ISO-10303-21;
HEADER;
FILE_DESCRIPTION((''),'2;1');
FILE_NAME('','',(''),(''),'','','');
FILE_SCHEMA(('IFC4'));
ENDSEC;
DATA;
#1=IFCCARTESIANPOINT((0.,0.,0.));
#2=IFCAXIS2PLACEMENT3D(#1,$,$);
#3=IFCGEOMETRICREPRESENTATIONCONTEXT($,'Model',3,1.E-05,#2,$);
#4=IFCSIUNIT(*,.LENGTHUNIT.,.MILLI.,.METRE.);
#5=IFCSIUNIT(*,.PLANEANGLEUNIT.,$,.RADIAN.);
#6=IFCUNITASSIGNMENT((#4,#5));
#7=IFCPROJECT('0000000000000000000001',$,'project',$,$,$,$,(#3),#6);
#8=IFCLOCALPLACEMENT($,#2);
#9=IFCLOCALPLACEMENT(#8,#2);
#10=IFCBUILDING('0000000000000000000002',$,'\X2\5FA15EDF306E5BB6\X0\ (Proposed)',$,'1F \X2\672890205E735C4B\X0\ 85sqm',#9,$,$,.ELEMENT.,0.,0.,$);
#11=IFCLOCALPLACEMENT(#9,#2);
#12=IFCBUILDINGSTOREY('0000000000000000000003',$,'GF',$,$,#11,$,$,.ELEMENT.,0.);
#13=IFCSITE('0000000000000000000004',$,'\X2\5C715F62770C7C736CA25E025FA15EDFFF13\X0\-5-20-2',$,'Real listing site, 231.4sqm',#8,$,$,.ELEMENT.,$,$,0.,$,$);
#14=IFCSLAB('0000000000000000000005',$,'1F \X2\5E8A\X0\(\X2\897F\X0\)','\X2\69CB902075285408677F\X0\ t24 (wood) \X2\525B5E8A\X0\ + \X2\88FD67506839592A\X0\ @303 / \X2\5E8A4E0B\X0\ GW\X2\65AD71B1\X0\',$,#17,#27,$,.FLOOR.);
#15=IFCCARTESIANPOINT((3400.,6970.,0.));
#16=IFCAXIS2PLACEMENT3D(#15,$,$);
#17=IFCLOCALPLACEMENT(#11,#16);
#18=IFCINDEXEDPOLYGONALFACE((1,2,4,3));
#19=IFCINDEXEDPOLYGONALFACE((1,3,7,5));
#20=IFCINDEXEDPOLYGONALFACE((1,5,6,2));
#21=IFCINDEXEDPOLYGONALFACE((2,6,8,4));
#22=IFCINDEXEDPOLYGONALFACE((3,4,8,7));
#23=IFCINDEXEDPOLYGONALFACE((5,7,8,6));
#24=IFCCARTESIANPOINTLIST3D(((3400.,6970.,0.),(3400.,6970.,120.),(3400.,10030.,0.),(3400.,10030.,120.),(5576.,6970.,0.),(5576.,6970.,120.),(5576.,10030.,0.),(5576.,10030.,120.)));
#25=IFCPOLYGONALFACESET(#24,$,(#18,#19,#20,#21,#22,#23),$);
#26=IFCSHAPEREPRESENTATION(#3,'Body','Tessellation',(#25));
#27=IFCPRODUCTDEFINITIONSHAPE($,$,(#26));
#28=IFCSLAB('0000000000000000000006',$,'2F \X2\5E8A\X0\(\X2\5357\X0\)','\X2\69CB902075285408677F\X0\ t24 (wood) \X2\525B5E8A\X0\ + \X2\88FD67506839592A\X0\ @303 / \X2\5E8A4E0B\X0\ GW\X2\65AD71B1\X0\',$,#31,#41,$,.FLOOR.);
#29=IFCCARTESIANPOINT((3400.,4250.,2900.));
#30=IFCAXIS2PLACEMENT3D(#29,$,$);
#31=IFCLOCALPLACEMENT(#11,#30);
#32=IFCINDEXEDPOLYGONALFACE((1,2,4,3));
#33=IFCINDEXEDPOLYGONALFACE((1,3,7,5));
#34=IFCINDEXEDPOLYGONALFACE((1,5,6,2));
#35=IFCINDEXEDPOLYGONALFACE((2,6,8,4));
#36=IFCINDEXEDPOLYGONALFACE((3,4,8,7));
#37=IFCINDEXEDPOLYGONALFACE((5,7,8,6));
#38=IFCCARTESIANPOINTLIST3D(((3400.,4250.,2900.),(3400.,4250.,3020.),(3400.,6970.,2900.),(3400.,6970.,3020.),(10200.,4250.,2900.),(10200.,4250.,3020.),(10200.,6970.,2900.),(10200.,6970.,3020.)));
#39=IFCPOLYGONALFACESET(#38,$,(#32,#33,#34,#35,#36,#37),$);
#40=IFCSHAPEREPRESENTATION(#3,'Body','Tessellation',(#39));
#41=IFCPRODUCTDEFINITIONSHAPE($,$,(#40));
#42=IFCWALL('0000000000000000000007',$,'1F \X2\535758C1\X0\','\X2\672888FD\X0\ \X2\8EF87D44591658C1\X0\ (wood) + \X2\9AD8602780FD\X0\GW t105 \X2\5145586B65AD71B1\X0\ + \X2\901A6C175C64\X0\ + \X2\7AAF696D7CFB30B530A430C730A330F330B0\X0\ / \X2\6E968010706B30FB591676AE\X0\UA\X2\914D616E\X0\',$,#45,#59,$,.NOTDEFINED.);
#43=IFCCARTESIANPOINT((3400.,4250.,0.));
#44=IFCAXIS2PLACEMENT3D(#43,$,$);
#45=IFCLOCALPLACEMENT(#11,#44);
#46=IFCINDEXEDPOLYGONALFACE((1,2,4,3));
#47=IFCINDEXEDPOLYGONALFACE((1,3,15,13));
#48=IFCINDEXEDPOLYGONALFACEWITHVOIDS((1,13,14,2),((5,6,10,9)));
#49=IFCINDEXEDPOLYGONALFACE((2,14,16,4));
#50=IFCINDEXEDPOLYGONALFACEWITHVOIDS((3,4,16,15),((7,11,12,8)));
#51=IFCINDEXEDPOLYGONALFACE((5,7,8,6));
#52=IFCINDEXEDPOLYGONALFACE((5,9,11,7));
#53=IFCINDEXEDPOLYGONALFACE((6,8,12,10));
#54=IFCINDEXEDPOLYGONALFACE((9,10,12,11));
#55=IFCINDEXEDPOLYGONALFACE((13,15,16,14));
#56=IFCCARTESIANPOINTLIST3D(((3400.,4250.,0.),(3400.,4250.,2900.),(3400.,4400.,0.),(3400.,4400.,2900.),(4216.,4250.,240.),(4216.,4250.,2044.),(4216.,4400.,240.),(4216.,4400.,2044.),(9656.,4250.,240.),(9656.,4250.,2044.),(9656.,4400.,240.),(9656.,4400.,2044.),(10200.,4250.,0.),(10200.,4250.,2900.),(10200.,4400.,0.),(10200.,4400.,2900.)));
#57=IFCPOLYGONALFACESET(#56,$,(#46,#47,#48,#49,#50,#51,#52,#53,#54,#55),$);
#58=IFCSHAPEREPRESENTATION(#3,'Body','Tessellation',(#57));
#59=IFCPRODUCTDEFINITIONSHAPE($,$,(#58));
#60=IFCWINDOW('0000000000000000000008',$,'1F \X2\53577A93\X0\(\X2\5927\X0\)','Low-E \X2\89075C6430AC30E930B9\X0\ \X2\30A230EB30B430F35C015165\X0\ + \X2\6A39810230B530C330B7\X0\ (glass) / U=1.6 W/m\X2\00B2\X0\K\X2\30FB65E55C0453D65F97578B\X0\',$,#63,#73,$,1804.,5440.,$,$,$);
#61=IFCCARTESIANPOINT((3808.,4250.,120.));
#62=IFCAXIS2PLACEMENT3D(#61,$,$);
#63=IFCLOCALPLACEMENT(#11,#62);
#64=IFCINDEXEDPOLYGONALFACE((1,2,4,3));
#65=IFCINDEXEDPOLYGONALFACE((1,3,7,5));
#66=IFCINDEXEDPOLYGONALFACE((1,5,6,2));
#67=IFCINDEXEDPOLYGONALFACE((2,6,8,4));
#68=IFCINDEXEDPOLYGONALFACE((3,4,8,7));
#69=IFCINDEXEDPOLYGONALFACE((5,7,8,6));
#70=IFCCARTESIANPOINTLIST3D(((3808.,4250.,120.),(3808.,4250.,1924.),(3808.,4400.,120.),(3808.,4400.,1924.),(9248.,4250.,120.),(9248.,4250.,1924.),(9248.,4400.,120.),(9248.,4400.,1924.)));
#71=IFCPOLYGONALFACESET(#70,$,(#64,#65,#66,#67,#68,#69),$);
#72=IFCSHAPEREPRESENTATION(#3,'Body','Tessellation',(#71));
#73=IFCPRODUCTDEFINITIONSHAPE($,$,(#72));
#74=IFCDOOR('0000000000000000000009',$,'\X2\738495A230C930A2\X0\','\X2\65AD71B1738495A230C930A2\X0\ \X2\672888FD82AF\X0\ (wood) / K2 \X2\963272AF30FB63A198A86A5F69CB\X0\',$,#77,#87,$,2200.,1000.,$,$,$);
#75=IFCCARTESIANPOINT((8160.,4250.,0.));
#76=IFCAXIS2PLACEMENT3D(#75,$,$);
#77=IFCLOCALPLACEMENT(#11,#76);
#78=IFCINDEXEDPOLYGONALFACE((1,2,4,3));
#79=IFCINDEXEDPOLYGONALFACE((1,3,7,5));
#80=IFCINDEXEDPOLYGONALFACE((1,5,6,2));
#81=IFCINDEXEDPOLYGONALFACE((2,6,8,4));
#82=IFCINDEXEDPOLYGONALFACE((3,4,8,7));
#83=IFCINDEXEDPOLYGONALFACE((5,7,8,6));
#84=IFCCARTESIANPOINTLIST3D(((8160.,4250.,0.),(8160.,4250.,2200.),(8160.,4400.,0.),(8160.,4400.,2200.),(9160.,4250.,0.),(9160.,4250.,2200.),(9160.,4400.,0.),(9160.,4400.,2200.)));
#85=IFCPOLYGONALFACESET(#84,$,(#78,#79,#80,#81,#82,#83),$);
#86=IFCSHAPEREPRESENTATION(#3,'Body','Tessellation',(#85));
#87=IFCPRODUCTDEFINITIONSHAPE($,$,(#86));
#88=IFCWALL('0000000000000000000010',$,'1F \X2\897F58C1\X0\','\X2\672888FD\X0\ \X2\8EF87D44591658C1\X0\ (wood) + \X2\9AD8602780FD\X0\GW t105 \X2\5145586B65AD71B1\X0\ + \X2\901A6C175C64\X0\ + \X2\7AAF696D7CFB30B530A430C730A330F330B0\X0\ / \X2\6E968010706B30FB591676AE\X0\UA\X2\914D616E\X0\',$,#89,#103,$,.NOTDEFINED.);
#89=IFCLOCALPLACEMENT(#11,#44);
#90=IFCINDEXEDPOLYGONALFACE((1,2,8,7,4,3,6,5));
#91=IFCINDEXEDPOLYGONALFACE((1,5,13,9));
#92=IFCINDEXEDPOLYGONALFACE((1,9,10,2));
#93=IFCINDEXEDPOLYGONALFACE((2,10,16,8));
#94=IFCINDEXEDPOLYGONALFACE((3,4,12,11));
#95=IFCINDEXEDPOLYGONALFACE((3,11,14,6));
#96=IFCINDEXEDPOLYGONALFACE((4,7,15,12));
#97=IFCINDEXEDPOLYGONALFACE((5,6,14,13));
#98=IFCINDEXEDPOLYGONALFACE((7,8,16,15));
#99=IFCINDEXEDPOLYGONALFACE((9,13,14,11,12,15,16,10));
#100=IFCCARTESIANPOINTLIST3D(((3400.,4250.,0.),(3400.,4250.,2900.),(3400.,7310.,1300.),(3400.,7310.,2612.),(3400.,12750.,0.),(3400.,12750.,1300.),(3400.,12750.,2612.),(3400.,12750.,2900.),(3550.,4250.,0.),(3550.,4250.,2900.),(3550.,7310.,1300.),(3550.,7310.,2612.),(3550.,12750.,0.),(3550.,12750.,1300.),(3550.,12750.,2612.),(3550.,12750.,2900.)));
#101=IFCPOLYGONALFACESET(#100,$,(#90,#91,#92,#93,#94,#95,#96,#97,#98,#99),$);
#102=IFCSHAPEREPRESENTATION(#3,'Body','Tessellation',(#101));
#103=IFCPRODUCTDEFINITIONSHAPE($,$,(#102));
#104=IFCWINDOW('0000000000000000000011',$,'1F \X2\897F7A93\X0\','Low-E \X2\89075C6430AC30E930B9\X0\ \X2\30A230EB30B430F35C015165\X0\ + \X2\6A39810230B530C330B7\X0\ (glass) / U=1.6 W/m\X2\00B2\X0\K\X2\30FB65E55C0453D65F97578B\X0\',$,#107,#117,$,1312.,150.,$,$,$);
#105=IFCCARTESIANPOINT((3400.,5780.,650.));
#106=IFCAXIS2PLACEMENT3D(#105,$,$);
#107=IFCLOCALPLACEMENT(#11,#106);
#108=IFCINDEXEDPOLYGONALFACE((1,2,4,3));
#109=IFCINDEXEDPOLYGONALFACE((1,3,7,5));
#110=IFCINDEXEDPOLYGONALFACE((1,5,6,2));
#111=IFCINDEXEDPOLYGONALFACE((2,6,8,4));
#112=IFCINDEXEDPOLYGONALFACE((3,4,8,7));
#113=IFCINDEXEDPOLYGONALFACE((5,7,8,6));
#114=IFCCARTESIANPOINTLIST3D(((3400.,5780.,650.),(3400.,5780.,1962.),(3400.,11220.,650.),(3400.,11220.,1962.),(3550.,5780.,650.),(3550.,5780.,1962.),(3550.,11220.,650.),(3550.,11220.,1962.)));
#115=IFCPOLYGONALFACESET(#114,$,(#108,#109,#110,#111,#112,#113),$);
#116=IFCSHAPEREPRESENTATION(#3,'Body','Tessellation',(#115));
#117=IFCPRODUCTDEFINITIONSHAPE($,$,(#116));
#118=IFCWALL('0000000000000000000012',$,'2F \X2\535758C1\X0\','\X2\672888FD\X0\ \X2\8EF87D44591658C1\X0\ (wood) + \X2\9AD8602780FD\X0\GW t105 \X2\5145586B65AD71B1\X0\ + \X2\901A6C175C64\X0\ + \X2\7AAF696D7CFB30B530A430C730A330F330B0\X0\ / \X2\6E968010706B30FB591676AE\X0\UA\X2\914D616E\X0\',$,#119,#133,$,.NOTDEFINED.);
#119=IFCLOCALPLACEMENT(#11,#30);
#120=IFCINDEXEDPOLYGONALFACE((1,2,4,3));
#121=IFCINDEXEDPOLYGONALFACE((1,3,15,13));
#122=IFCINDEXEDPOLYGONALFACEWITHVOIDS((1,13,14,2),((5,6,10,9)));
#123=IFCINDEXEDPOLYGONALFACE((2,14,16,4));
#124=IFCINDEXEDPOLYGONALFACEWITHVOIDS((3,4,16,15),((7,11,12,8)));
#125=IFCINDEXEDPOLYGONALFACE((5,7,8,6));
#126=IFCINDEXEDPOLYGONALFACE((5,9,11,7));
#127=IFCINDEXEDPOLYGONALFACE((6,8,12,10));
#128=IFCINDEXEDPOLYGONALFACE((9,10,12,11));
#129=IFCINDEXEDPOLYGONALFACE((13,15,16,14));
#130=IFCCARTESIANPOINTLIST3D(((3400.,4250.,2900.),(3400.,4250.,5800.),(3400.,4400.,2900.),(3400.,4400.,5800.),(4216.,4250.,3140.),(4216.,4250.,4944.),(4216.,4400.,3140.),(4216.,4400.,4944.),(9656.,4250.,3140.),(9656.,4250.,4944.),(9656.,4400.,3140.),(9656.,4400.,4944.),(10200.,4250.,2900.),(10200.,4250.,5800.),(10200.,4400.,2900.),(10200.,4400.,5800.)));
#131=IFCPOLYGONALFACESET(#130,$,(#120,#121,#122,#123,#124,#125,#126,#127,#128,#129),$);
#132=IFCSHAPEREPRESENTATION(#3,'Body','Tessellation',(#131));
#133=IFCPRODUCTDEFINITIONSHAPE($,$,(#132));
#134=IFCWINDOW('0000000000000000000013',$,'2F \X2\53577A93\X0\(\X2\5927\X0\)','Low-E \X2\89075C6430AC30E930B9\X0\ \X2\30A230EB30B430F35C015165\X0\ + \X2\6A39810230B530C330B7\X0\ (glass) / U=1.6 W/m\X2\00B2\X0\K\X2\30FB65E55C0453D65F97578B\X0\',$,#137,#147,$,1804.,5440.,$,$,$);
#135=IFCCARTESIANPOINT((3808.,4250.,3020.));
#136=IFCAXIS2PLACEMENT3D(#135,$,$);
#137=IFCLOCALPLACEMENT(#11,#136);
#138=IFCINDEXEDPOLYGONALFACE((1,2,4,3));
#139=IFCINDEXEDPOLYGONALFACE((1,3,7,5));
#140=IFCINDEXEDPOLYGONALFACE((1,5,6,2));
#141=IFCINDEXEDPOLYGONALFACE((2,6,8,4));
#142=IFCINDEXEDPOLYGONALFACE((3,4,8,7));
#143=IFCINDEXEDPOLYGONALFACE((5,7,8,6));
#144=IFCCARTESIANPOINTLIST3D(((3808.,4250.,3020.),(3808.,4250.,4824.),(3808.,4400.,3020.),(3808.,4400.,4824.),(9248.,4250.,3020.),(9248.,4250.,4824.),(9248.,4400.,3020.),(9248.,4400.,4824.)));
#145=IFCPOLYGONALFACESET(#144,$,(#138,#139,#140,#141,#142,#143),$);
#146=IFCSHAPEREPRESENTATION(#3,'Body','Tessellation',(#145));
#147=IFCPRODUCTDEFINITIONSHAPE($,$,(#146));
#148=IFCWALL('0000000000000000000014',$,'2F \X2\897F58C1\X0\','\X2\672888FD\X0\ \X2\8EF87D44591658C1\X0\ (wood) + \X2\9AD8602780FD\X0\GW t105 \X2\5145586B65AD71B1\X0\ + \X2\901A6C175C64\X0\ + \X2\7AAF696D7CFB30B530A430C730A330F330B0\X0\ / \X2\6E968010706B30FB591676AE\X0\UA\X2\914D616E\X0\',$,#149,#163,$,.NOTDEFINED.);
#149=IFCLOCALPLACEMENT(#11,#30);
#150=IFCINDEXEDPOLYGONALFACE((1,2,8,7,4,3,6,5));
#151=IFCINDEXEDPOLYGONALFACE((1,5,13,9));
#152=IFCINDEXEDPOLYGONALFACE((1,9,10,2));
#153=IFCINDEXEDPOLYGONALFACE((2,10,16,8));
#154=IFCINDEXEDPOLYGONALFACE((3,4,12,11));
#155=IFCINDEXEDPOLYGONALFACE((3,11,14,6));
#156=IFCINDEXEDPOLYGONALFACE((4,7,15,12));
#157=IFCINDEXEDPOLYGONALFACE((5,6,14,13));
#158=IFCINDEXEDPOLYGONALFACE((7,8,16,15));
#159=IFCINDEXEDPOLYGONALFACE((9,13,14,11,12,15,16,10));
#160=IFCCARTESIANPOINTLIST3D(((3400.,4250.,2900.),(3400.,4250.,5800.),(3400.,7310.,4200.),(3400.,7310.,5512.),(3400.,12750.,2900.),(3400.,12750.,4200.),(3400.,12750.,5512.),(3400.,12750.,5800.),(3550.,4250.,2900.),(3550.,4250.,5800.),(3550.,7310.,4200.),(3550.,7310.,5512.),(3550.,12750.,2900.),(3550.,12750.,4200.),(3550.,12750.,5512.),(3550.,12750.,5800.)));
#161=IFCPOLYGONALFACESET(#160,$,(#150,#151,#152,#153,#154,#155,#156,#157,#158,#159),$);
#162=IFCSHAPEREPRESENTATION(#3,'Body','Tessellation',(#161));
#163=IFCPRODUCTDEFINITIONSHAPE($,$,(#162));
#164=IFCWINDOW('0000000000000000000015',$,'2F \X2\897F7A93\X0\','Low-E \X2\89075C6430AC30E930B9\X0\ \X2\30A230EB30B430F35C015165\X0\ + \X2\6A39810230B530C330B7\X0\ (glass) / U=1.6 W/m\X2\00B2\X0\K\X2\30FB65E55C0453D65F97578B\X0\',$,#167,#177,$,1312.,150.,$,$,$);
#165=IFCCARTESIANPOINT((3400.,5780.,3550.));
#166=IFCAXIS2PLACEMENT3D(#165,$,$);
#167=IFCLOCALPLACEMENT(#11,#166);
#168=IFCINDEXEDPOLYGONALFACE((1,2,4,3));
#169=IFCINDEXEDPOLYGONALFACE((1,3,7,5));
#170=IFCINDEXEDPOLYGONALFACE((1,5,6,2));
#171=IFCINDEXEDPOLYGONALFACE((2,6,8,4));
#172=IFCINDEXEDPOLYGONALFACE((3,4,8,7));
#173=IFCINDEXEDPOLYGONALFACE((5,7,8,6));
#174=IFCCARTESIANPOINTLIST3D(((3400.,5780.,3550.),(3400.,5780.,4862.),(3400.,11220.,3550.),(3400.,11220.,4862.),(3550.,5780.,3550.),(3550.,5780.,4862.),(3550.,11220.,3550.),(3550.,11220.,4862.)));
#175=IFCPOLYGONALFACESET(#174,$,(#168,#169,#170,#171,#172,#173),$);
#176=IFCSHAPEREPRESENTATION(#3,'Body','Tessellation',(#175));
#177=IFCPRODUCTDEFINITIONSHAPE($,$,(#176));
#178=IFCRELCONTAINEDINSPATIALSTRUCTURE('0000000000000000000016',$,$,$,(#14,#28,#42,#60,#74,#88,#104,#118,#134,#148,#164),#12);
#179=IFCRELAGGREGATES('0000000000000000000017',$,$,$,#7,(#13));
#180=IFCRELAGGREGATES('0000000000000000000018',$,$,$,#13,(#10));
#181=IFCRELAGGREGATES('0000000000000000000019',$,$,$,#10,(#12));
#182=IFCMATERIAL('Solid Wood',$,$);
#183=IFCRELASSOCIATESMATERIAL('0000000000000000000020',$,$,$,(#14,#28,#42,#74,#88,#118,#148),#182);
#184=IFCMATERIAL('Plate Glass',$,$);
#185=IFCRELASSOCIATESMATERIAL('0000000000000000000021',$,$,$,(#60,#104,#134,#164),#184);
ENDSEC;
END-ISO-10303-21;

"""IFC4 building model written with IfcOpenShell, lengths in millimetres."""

from ifc_helpers import new_model, si_unit, frame, frame_2d, origin, place, context, project, spatial, rectangle, extrude, material, element, fill, save


model = new_model("IFC4")

# Units and contexts
model_context = context("Model", 3, precision=1e-05, world=origin())
ifc_project = project(units=[si_unit("LENGTHUNIT", "METRE", prefix="MILLI"), si_unit("PLANEANGLEUNIT", "RADIAN")], contexts=[model_context])

# Site, building, storey
site_placement = place(None, origin())
site = spatial("IfcSite", under=ifc_project, at=site_placement, Name="山形県米沢市御廟３-5-20-2", ObjectType="Real listing site, 231.4sqm", CompositionType="ELEMENT", RefElevation=0.0)
building_placement = place(site_placement, origin())
building = spatial("IfcBuilding", under=site, at=building_placement, Name="御廟の家 (Proposed)", ObjectType="1F 木造平屋 85sqm", CompositionType="ELEMENT", ElevationOfRefHeight=0.0, ElevationOfTerrain=0.0)
storey_placement = place(building_placement, origin())
storey = spatial("IfcBuildingStorey", under=building, at=storey_placement, Name="GF", CompositionType="ELEMENT", Elevation=0.0)

# Slabs
ifc_material_1 = material(Name="Solid Wood")
slab_1_placement = place(storey_placement, frame((3400.0, 6970.0, 0.0)))
element("IfcSlab", 1, at=slab_1_placement, inside=storey, material=ifc_material_1, Name="1F 床(西)", Description="構造用合板 t24 (wood) 剛床 + 製材根太 @303 / 床下 GW断熱", PredefinedType="FLOOR", context=model_context, shape_type="SweptSolid", body=[
    extrude(rectangle(XDim=2176.0, YDim=3060.0, at=frame_2d((1088.0, 1530.0))), frame((3400.0, 6970.0, 0.0)), (0.0, 0.0, 1.0), 120.0),
])
slab_2_placement = place(storey_placement, frame((3400.0, 4250.0, 2900.0)))
element("IfcSlab", 2, at=slab_2_placement, inside=storey, material=ifc_material_1, Name="2F 床(南)", Description="構造用合板 t24 (wood) 剛床 + 製材根太 @303 / 床下 GW断熱", PredefinedType="FLOOR", context=model_context, shape_type="SweptSolid", body=[
    extrude(rectangle(XDim=6800.0, YDim=2720.0, at=frame_2d((3400.0, 1360.0))), frame((3400.0, 4250.0, 2900.0)), (0.0, 0.0, 1.0), 120.0),
])

# Wall, openings, window, door
wall_1_placement = place(storey_placement, frame((3400.0, 4250.0, 0.0)))
wall_1 = element("IfcWall", 3, at=wall_1_placement, inside=storey, material=ifc_material_1, Name="1F 南壁", Description="木製 軸組外壁 (wood) + 高性能GW t105 充填断熱 + 通気層 + 窯業系サイディング / 準耐火・外皮UA配慮", PredefinedType="NOTDEFINED", context=model_context, shape_type="SweptSolid", body=[
    extrude(rectangle(XDim=6800.0, YDim=150.0, at=frame_2d((3400.0, 75.0))), frame((3400.0, 4250.0, 0.0)), (0.0, 0.0, 1.0), 2900.0),
])
opening_1_placement = place(storey_placement, frame((3808.0, 4250.0, 120.0)))
opening_1 = element("IfcOpeningElement", 4, at=opening_1_placement, cuts=wall_1, PredefinedType="NOTDEFINED", context=model_context, shape_type="SweptSolid", body=[
    extrude(rectangle(XDim=5440.0, YDim=150.0, at=frame_2d((2720.0, 75.0))), frame((3808.0, 4250.0, 120.0)), (0.0, 0.0, 1.0), 1804.0),
])
opening_2_placement = place(storey_placement, frame((8160.0, 4250.0, 0.0)))
opening_2 = element("IfcOpeningElement", 5, at=opening_2_placement, cuts=wall_1, PredefinedType="NOTDEFINED", context=model_context, shape_type="SweptSolid", body=[
    extrude(rectangle(XDim=1000.0, YDim=150.0, at=frame_2d((500.0, 75.0))), frame((8160.0, 4250.0, 0.0)), (0.0, 0.0, 1.0), 2200.0),
])
ifc_material_2 = material(Name="Plate Glass")
window_1_placement = place(storey_placement, frame((3808.0, 4250.0, 120.0)))
window_1 = element("IfcWindow", 6, at=window_1_placement, inside=storey, material=ifc_material_2, Name="1F 南窓(大)", Description="Low-E 複層ガラス アルゴン封入 + 樹脂サッシ (glass) / U=1.6 W/m²K・日射取得型", OverallHeight=1804.0, OverallWidth=5440.0, context=model_context, shape_type="SweptSolid", body=[
    extrude(rectangle(XDim=5440.0, YDim=150.0, at=frame_2d((2720.0, 75.0))), frame((3808.0, 4250.0, 120.0)), (0.0, 0.0, 1.0), 1804.0),
])
fill(opening_1, window_1)
door_placement = place(storey_placement, frame((8160.0, 4250.0, 0.0)))
door = element("IfcDoor", 7, at=door_placement, inside=storey, material=ifc_material_1, Name="玄関ドア", Description="断熱玄関ドア 木製芯 (wood) / K2 防犯・採風機構", OverallHeight=2200.0, OverallWidth=1000.0, context=model_context, shape_type="SweptSolid", body=[
    extrude(rectangle(XDim=1000.0, YDim=150.0, at=frame_2d((500.0, 75.0))), frame((8160.0, 4250.0, 0.0)), (0.0, 0.0, 1.0), 2200.0),
])
fill(opening_2, door)

# Walls, openings, windows
wall_2_placement = place(storey_placement, frame((3400.0, 4250.0, 0.0)))
wall_2 = element("IfcWall", 8, at=wall_2_placement, inside=storey, material=ifc_material_1, Name="1F 西壁", Description="木製 軸組外壁 (wood) + 高性能GW t105 充填断熱 + 通気層 + 窯業系サイディング / 準耐火・外皮UA配慮", PredefinedType="NOTDEFINED", context=model_context, shape_type="SweptSolid", body=[
    extrude(rectangle(XDim=150.0, YDim=8500.0, at=frame_2d((75.0, 4250.0))), frame((3400.0, 4250.0, 0.0)), (0.0, 0.0, 1.0), 2900.0),
])
opening_3_placement = place(storey_placement, frame((3400.0, 5780.0, 650.0)))
opening_3 = element("IfcOpeningElement", 9, at=opening_3_placement, cuts=wall_2, PredefinedType="NOTDEFINED", context=model_context, shape_type="SweptSolid", body=[
    extrude(rectangle(XDim=150.0, YDim=5440.0, at=frame_2d((75.0, 2720.0))), frame((3400.0, 5780.0, 650.0)), (0.0, 0.0, 1.0), 1312.0),
])
window_2_placement = place(storey_placement, frame((3400.0, 5780.0, 650.0)))
window_2 = element("IfcWindow", 10, at=window_2_placement, inside=storey, material=ifc_material_2, Name="1F 西窓", Description="Low-E 複層ガラス アルゴン封入 + 樹脂サッシ (glass) / U=1.6 W/m²K・日射取得型", OverallHeight=1312.0, OverallWidth=150.0, context=model_context, shape_type="SweptSolid", body=[
    extrude(rectangle(XDim=150.0, YDim=5440.0, at=frame_2d((75.0, 2720.0))), frame((3400.0, 5780.0, 650.0)), (0.0, 0.0, 1.0), 1312.0),
])
fill(opening_3, window_2)
wall_3_placement = place(storey_placement, frame((3400.0, 4250.0, 2900.0)))
wall_3 = element("IfcWall", 11, at=wall_3_placement, inside=storey, material=ifc_material_1, Name="2F 南壁", Description="木製 軸組外壁 (wood) + 高性能GW t105 充填断熱 + 通気層 + 窯業系サイディング / 準耐火・外皮UA配慮", PredefinedType="NOTDEFINED", context=model_context, shape_type="SweptSolid", body=[
    extrude(rectangle(XDim=6800.0, YDim=150.0, at=frame_2d((3400.0, 75.0))), frame((3400.0, 4250.0, 2900.0)), (0.0, 0.0, 1.0), 2900.0),
])
opening_4_placement = place(storey_placement, frame((3808.0, 4250.0, 3020.0)))
opening_4 = element("IfcOpeningElement", 12, at=opening_4_placement, cuts=wall_3, PredefinedType="NOTDEFINED", context=model_context, shape_type="SweptSolid", body=[
    extrude(rectangle(XDim=5440.0, YDim=150.0, at=frame_2d((2720.0, 75.0))), frame((3808.0, 4250.0, 3020.0)), (0.0, 0.0, 1.0), 1804.0),
])
window_3_placement = place(storey_placement, frame((3808.0, 4250.0, 3020.0)))
window_3 = element("IfcWindow", 13, at=window_3_placement, inside=storey, material=ifc_material_2, Name="2F 南窓(大)", Description="Low-E 複層ガラス アルゴン封入 + 樹脂サッシ (glass) / U=1.6 W/m²K・日射取得型", OverallHeight=1804.0, OverallWidth=5440.0, context=model_context, shape_type="SweptSolid", body=[
    extrude(rectangle(XDim=5440.0, YDim=150.0, at=frame_2d((2720.0, 75.0))), frame((3808.0, 4250.0, 3020.0)), (0.0, 0.0, 1.0), 1804.0),
])
fill(opening_4, window_3)
wall_4_placement = place(storey_placement, frame((3400.0, 4250.0, 2900.0)))
wall_4 = element("IfcWall", 14, at=wall_4_placement, inside=storey, material=ifc_material_1, Name="2F 西壁", Description="木製 軸組外壁 (wood) + 高性能GW t105 充填断熱 + 通気層 + 窯業系サイディング / 準耐火・外皮UA配慮", PredefinedType="NOTDEFINED", context=model_context, shape_type="SweptSolid", body=[
    extrude(rectangle(XDim=150.0, YDim=8500.0, at=frame_2d((75.0, 4250.0))), frame((3400.0, 4250.0, 2900.0)), (0.0, 0.0, 1.0), 2900.0),
])
opening_5_placement = place(storey_placement, frame((3400.0, 5780.0, 3550.0)))
opening_5 = element("IfcOpeningElement", 15, at=opening_5_placement, cuts=wall_4, PredefinedType="NOTDEFINED", context=model_context, shape_type="SweptSolid", body=[
    extrude(rectangle(XDim=150.0, YDim=5440.0, at=frame_2d((75.0, 2720.0))), frame((3400.0, 5780.0, 3550.0)), (0.0, 0.0, 1.0), 1312.0),
])
window_4_placement = place(storey_placement, frame((3400.0, 5780.0, 3550.0)))
window_4 = element("IfcWindow", 16, at=window_4_placement, inside=storey, material=ifc_material_2, Name="2F 西窓", Description="Low-E 複層ガラス アルゴン封入 + 樹脂サッシ (glass) / U=1.6 W/m²K・日射取得型", OverallHeight=1312.0, OverallWidth=150.0, context=model_context, shape_type="SweptSolid", body=[
    extrude(rectangle(XDim=150.0, YDim=5440.0, at=frame_2d((75.0, 2720.0))), frame((3400.0, 5780.0, 3550.0)), (0.0, 0.0, 1.0), 1312.0),
])
fill(opening_5, window_4)

save(model, "model.ifc")
